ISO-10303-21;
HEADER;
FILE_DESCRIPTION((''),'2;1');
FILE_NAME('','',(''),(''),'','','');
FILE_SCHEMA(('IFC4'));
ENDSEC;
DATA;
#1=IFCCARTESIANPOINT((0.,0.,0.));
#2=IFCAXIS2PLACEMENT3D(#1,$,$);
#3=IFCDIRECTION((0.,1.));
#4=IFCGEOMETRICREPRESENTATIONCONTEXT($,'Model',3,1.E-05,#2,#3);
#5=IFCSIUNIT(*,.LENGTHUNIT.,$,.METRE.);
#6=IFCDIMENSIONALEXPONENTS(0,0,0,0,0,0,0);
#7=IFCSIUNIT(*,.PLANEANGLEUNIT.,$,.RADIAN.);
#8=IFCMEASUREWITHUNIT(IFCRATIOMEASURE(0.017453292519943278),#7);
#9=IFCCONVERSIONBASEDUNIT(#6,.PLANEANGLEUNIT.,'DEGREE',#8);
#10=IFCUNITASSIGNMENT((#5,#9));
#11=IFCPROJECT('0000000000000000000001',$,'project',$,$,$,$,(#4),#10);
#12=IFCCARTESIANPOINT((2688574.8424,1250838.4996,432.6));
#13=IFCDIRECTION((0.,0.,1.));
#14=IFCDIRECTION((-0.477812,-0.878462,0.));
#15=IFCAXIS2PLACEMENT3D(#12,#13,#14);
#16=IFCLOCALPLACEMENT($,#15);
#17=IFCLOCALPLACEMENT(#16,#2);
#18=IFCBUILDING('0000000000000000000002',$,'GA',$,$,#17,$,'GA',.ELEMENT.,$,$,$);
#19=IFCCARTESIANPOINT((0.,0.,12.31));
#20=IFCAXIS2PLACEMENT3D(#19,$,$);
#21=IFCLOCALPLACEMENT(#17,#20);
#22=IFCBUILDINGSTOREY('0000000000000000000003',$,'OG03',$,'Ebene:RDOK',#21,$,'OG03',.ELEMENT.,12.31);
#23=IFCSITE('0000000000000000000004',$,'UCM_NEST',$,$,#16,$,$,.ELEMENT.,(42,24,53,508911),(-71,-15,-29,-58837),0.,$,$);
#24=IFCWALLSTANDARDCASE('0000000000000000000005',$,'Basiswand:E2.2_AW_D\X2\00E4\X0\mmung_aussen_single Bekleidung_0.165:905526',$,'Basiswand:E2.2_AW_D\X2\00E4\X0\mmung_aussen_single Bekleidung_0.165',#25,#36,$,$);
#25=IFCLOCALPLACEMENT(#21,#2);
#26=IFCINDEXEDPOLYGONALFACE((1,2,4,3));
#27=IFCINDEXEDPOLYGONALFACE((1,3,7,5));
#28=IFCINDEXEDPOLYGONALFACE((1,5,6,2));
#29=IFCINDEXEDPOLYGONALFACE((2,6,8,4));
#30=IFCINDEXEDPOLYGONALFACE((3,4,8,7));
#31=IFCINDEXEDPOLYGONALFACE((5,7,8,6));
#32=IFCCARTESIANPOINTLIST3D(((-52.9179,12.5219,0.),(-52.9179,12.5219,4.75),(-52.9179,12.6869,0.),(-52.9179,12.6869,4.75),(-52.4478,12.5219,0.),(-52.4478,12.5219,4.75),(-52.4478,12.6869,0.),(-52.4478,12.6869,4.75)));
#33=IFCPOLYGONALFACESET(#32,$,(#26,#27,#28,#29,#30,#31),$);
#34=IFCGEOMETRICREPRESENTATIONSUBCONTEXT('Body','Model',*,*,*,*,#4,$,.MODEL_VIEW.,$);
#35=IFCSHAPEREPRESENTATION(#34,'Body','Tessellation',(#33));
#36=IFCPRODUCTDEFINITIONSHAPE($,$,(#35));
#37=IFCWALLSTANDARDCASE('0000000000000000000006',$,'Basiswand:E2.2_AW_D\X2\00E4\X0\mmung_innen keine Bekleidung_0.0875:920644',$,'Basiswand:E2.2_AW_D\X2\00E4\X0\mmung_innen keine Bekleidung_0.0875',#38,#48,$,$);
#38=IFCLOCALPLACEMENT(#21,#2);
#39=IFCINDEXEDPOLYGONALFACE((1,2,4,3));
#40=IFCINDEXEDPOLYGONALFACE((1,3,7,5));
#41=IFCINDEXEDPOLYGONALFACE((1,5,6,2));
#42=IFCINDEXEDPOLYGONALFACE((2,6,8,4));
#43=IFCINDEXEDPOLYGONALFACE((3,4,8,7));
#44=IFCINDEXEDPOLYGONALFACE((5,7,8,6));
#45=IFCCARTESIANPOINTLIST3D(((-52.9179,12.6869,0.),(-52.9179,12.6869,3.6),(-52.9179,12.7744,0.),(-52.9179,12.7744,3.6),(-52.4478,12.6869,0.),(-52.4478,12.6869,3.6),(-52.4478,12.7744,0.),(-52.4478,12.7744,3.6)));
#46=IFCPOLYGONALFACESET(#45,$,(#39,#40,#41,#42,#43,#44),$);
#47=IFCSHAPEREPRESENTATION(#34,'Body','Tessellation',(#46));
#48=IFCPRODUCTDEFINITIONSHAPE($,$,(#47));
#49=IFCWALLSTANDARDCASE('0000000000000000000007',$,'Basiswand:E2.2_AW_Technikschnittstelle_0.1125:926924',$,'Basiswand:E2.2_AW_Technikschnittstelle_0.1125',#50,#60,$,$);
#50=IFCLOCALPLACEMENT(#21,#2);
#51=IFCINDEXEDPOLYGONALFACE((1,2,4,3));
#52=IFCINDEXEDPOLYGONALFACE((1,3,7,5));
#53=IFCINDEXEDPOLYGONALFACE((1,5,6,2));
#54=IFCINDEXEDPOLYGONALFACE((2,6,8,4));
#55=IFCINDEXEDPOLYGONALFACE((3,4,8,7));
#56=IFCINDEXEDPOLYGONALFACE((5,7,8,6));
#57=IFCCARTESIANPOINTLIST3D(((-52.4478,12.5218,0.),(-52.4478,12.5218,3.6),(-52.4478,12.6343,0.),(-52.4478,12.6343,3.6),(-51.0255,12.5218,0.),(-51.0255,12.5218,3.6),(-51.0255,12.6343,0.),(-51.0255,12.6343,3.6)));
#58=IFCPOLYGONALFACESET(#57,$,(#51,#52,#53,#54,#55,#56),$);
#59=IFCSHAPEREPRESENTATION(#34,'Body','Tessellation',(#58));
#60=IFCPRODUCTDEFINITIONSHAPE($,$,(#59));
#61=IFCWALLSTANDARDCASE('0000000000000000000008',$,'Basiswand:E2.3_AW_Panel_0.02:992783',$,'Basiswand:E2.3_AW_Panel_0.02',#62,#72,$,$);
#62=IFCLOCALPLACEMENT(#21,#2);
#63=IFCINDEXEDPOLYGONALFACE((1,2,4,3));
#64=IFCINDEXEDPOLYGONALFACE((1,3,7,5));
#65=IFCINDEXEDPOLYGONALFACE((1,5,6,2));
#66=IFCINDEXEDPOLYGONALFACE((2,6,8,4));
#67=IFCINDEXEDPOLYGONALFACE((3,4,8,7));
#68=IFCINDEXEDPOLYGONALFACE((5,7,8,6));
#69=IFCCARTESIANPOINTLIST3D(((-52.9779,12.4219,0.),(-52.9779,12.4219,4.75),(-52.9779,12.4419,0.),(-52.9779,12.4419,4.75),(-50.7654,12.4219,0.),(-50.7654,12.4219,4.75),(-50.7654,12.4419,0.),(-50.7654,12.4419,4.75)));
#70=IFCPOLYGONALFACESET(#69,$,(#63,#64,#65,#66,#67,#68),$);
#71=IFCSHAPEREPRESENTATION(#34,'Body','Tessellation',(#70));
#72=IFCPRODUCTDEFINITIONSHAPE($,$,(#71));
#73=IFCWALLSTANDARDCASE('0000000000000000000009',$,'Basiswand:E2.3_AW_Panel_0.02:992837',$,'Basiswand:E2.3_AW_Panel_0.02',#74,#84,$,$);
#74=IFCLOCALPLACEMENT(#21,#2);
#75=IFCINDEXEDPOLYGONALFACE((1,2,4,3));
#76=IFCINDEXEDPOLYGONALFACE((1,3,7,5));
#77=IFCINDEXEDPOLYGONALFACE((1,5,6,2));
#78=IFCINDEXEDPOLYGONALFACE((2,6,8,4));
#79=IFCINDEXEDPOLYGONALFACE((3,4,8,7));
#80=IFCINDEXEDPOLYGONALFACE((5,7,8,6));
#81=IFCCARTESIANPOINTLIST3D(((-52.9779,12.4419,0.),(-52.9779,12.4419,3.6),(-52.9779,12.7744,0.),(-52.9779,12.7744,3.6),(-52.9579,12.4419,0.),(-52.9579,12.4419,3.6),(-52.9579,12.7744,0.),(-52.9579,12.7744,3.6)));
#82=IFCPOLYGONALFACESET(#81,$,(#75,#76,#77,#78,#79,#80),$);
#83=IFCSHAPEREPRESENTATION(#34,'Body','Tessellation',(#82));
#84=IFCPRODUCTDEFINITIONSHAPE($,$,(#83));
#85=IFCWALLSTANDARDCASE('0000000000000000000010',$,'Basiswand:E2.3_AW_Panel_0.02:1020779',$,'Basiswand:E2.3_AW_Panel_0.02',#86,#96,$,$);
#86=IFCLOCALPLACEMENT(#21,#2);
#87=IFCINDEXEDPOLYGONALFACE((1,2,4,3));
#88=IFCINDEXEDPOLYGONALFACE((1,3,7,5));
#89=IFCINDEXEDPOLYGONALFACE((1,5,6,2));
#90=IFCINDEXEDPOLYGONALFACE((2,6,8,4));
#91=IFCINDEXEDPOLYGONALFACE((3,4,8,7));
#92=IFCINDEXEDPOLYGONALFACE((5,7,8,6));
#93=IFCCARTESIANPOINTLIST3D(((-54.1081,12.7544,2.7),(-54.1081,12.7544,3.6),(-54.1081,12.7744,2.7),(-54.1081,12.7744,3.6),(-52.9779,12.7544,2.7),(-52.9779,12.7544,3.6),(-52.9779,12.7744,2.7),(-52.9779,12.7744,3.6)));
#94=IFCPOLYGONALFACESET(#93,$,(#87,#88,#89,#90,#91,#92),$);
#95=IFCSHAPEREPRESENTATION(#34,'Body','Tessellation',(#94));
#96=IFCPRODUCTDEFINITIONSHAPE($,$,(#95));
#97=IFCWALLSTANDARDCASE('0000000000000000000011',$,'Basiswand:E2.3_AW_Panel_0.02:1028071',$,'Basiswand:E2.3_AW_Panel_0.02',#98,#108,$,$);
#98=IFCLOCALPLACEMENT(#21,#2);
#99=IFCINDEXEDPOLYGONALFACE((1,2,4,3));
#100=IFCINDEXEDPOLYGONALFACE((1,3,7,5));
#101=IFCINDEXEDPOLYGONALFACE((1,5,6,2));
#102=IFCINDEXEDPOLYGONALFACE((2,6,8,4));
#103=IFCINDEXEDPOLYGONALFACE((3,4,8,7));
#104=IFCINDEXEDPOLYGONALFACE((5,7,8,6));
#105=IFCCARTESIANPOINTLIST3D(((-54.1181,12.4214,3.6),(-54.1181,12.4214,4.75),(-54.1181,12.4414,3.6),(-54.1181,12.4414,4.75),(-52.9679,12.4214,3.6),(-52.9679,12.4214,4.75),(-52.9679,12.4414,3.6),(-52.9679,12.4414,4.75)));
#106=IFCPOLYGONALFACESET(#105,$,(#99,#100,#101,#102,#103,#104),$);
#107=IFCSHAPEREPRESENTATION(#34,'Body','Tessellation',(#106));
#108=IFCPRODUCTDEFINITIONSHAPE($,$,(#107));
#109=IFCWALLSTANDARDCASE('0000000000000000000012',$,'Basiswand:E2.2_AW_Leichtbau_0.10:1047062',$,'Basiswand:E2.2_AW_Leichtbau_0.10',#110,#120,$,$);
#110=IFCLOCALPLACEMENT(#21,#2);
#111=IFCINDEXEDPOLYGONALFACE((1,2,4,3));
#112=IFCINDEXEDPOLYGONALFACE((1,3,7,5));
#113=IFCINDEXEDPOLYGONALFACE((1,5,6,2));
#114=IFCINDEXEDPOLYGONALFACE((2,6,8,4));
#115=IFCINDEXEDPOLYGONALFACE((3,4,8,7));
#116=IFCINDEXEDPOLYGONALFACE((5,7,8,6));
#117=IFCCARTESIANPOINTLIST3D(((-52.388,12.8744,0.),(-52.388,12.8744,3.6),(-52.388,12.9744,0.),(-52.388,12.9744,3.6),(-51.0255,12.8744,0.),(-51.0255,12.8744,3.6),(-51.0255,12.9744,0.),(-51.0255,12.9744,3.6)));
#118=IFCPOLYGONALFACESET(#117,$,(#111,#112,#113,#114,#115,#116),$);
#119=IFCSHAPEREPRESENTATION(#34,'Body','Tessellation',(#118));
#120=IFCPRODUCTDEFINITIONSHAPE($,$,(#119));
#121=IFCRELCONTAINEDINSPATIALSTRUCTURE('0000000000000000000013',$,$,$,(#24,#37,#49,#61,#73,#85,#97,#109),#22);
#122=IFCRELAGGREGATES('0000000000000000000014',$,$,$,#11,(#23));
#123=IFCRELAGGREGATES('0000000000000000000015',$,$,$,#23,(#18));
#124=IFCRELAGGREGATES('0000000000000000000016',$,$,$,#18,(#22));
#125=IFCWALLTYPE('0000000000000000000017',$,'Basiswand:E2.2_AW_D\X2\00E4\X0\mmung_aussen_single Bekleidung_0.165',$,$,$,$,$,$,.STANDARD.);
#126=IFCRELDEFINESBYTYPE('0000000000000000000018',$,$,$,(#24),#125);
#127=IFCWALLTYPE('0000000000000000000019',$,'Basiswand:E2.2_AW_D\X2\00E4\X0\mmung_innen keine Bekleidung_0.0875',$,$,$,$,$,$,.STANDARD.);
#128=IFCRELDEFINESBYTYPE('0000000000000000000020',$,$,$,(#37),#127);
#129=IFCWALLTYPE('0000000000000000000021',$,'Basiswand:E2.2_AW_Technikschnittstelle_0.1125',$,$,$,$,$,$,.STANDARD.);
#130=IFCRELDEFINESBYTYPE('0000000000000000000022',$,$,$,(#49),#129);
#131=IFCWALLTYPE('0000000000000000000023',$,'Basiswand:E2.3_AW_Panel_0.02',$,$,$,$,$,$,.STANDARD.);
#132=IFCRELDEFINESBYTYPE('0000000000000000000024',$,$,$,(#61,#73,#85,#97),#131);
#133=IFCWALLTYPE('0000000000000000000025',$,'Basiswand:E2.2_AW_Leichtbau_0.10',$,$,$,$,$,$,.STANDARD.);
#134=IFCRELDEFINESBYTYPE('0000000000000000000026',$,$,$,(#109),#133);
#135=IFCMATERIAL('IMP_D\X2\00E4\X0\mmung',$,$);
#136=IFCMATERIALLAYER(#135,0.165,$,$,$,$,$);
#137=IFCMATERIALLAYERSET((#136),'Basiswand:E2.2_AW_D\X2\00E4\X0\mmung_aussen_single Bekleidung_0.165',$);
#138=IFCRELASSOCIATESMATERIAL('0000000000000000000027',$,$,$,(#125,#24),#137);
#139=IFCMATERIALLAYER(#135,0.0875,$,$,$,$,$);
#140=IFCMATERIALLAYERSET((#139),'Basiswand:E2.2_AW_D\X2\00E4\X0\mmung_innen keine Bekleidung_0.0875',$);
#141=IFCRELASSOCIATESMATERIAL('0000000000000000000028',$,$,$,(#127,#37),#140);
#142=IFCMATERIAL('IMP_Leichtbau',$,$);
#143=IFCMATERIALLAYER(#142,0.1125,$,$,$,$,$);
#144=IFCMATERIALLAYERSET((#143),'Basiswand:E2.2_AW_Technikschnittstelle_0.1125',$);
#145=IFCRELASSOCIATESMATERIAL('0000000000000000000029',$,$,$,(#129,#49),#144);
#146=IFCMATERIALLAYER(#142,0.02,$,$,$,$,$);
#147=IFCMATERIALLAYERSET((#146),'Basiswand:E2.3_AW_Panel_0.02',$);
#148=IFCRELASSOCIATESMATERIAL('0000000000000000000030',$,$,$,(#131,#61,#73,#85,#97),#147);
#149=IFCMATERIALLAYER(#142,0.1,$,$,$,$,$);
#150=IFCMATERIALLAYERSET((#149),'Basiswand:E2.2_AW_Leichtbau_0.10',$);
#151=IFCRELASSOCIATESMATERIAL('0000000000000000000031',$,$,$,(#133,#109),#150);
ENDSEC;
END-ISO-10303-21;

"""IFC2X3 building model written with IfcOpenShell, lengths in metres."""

from ifc_helpers import new_model, entity, si_unit, converted_unit, direction, frame, frame_2d, origin, place, context, subcontext, project, spatial, rectangle, extrude, material, layer, layer_set, layer_usage, type_object, element, save


model = new_model("IFC2X3")

# Units and contexts
model_context = context("Model", 3, precision=1e-05, world=origin(), true_north=direction((0.0, 1.0)))
body_context = subcontext(model_context, "Body", "Model", "MODEL_VIEW")
ifc_project = project(units=[si_unit("LENGTHUNIT", "METRE"), converted_unit("PLANEANGLEUNIT", "DEGREE", entity("IfcRatioMeasure", 0.017453292519943278), si_unit("PLANEANGLEUNIT", "RADIAN"), dimensions=[0, 0, 0, 0, 0, 0, 0])], contexts=[model_context])

# Site, building, storey
site_placement = place(None, frame((2688574.8424, 1250838.4996, 432.6), z_axis=(0.0, 0.0, 1.0), x_axis=(-0.477812, -0.878462, 0.0)))
site = spatial("IfcSite", under=ifc_project, at=site_placement, Name="UCM_NEST", CompositionType="ELEMENT", RefLatitude=(42, 24, 53, 508911), RefLongitude=(-71, -15, -29, -58837), RefElevation=0.0)
building_placement = place(site_placement, origin())
building = spatial("IfcBuilding", under=site, at=building_placement, Name="GA", LongName="GA", CompositionType="ELEMENT")
storey_placement = place(building_placement, frame((0.0, 0.0, 12.31)))
storey = spatial("IfcBuildingStorey", under=building, at=storey_placement, Name="OG03", ObjectType="Ebene:RDOK", LongName="OG03", CompositionType="ELEMENT", Elevation=12.31)

# Shared definitions
ifc_material_1 = material(Name="IMP_Dämmung")

# Wall
ifc_layer_1 = layer(ifc_material_1, 0.165)
ifc_layer_set_1 = layer_set([ifc_layer_1], Name="Basiswand:E2.2_AW_Dämmung_aussen_single Bekleidung_0.165")
ifc_layer_usage_1 = layer_usage(ifc_layer_set_1, "AXIS2", "NEGATIVE", 0.0825)
wall_type_1 = type_object("IfcWallType", Name="Basiswand:E2.2_AW_Dämmung_aussen_single Bekleidung_0.165", PredefinedType="STANDARD", material=ifc_layer_set_1)
wall_1_placement = place(storey_placement, frame((-52.4478, 12.6044, 0.0), z_axis=(0.0, 0.0, 1.0), x_axis=(-1.0, 0.0, 0.0)))
element("IfcWallStandardCase", 1, at=wall_1_placement, inside=storey, type_object=wall_type_1, material=ifc_layer_usage_1, Name="Basiswand:E2.2_AW_Dämmung_aussen_single Bekleidung_0.165:905526", ObjectType="Basiswand:E2.2_AW_Dämmung_aussen_single Bekleidung_0.165", context=body_context, shape_type="SweptSolid", body=[
    extrude(rectangle(XDim=0.4701, YDim=0.165, at=frame_2d((0.235, 0.0), x_axis=(-1.0, 0.0))), origin(), (0.0, 0.0, 1.0), 4.75),
])

# Walls
ifc_layer_2 = layer(ifc_material_1, 0.0875)
ifc_layer_set_2 = layer_set([ifc_layer_2], Name="Basiswand:E2.2_AW_Dämmung_innen keine Bekleidung_0.0875")
ifc_layer_usage_2 = layer_usage(ifc_layer_set_2, "AXIS2", "NEGATIVE", 0.0437)
wall_type_2 = type_object("IfcWallType", Name="Basiswand:E2.2_AW_Dämmung_innen keine Bekleidung_0.0875", PredefinedType="STANDARD", material=ifc_layer_set_2)
wall_2_placement = place(storey_placement, frame((-52.4478, 12.7307, 0.0), z_axis=(0.0, 0.0, 1.0), x_axis=(-1.0, 0.0, 0.0)))
element("IfcWallStandardCase", 2, at=wall_2_placement, inside=storey, type_object=wall_type_2, material=ifc_layer_usage_2, Name="Basiswand:E2.2_AW_Dämmung_innen keine Bekleidung_0.0875:920644", ObjectType="Basiswand:E2.2_AW_Dämmung_innen keine Bekleidung_0.0875", context=body_context, shape_type="SweptSolid", body=[
    extrude(rectangle(XDim=0.4701, YDim=0.0875, at=frame_2d((0.235, 0.0), x_axis=(-1.0, 0.0))), origin(), (0.0, 0.0, 1.0), 3.6),
])
ifc_material_2 = material(Name="IMP_Leichtbau")
ifc_layer_3 = layer(ifc_material_2, 0.1125)
ifc_layer_set_3 = layer_set([ifc_layer_3], Name="Basiswand:E2.2_AW_Technikschnittstelle_0.1125")
ifc_layer_usage_3 = layer_usage(ifc_layer_set_3, "AXIS2", "NEGATIVE", 0.0562)
wall_type_3 = type_object("IfcWallType", Name="Basiswand:E2.2_AW_Technikschnittstelle_0.1125", PredefinedType="STANDARD", material=ifc_layer_set_3)
wall_3_placement = place(storey_placement, frame((-52.4478, 12.578, 0.0)))
element("IfcWallStandardCase", 3, at=wall_3_placement, inside=storey, type_object=wall_type_3, material=ifc_layer_usage_3, Name="Basiswand:E2.2_AW_Technikschnittstelle_0.1125:926924", ObjectType="Basiswand:E2.2_AW_Technikschnittstelle_0.1125", context=body_context, shape_type="SweptSolid", body=[
    extrude(rectangle(XDim=1.4223, YDim=0.1125, at=frame_2d((0.7112, 0.0), x_axis=(-1.0, 0.0))), origin(), (0.0, 0.0, 1.0), 3.6),
])
ifc_layer_4 = layer(ifc_material_2, 0.02)
ifc_layer_set_4 = layer_set([ifc_layer_4], Name="Basiswand:E2.3_AW_Panel_0.02")
ifc_layer_usage_4 = layer_usage(ifc_layer_set_4, "AXIS2", "NEGATIVE", 0.01)
wall_type_4 = type_object("IfcWallType", Name="Basiswand:E2.3_AW_Panel_0.02", PredefinedType="STANDARD", material=ifc_layer_set_4)
wall_4_placement = place(storey_placement, frame((-50.7654, 12.4319, 0.0), z_axis=(0.0, 0.0, 1.0), x_axis=(-1.0, 0.0, 0.0)))
element("IfcWallStandardCase", 4, at=wall_4_placement, inside=storey, type_object=wall_type_4, material=ifc_layer_usage_4, Name="Basiswand:E2.3_AW_Panel_0.02:992783", ObjectType="Basiswand:E2.3_AW_Panel_0.02", context=body_context, shape_type="SweptSolid", body=[
    extrude(rectangle(XDim=2.2124, YDim=0.02, at=frame_2d((1.1062, 0.0), x_axis=(-1.0, 0.0))), origin(), (0.0, 0.0, 1.0), 4.75),
])
wall_5_placement = place(storey_placement, frame((-52.9679, 12.7744, 0.0), z_axis=(0.0, 0.0, 1.0), x_axis=(0.0, -1.0, 0.0)))
element("IfcWallStandardCase", 5, at=wall_5_placement, inside=storey, type_object=wall_type_4, material=ifc_layer_usage_4, Name="Basiswand:E2.3_AW_Panel_0.02:992837", ObjectType="Basiswand:E2.3_AW_Panel_0.02", context=body_context, shape_type="SweptSolid", body=[
    extrude(rectangle(XDim=0.3325, YDim=0.02, at=frame_2d((0.1663, 0.0), x_axis=(-1.0, 0.0))), origin(), (0.0, 0.0, 1.0), 3.6),
])
wall_6_placement = place(storey_placement, frame((-52.9779, 12.7644, 2.7), z_axis=(0.0, 0.0, 1.0), x_axis=(-1.0, 0.0, 0.0)))
element("IfcWallStandardCase", 6, at=wall_6_placement, inside=storey, type_object=wall_type_4, material=ifc_layer_usage_4, Name="Basiswand:E2.3_AW_Panel_0.02:1020779", ObjectType="Basiswand:E2.3_AW_Panel_0.02", context=body_context, shape_type="SweptSolid", body=[
    extrude(rectangle(XDim=1.1302, YDim=0.02, at=frame_2d((0.5651, 0.0), x_axis=(-1.0, 0.0))), origin(), (0.0, 0.0, 1.0), 0.9),
])
wall_7_placement = place(storey_placement, frame((-54.1181, 12.4314, 3.6)))
element("IfcWallStandardCase", 7, at=wall_7_placement, inside=storey, type_object=wall_type_4, material=ifc_layer_usage_4, Name="Basiswand:E2.3_AW_Panel_0.02:1028071", ObjectType="Basiswand:E2.3_AW_Panel_0.02", context=body_context, shape_type="SweptSolid", body=[
    extrude(rectangle(XDim=1.1502, YDim=0.02, at=frame_2d((0.5751, 0.0), x_axis=(-1.0, 0.0))), origin(), (0.0, 0.0, 1.0), 1.15),
])
ifc_layer_5 = layer(ifc_material_2, 0.1)
ifc_layer_set_5 = layer_set([ifc_layer_5], Name="Basiswand:E2.2_AW_Leichtbau_0.10")
ifc_layer_usage_5 = layer_usage(ifc_layer_set_5, "AXIS2", "NEGATIVE", 0.05)
wall_type_5 = type_object("IfcWallType", Name="Basiswand:E2.2_AW_Leichtbau_0.10", PredefinedType="STANDARD", material=ifc_layer_set_5)
wall_8_placement = place(storey_placement, frame((-52.388, 12.9244, 0.0)))
element("IfcWallStandardCase", 8, at=wall_8_placement, inside=storey, type_object=wall_type_5, material=ifc_layer_usage_5, Name="Basiswand:E2.2_AW_Leichtbau_0.10:1047062", ObjectType="Basiswand:E2.2_AW_Leichtbau_0.10", context=body_context, shape_type="SweptSolid", body=[
    extrude(rectangle(XDim=1.3625, YDim=0.1, at=frame_2d((0.6812, 0.0), x_axis=(-1.0, 0.0))), origin(), (0.0, 0.0, 1.0), 3.6),
])

save(model, "model.ifc")
